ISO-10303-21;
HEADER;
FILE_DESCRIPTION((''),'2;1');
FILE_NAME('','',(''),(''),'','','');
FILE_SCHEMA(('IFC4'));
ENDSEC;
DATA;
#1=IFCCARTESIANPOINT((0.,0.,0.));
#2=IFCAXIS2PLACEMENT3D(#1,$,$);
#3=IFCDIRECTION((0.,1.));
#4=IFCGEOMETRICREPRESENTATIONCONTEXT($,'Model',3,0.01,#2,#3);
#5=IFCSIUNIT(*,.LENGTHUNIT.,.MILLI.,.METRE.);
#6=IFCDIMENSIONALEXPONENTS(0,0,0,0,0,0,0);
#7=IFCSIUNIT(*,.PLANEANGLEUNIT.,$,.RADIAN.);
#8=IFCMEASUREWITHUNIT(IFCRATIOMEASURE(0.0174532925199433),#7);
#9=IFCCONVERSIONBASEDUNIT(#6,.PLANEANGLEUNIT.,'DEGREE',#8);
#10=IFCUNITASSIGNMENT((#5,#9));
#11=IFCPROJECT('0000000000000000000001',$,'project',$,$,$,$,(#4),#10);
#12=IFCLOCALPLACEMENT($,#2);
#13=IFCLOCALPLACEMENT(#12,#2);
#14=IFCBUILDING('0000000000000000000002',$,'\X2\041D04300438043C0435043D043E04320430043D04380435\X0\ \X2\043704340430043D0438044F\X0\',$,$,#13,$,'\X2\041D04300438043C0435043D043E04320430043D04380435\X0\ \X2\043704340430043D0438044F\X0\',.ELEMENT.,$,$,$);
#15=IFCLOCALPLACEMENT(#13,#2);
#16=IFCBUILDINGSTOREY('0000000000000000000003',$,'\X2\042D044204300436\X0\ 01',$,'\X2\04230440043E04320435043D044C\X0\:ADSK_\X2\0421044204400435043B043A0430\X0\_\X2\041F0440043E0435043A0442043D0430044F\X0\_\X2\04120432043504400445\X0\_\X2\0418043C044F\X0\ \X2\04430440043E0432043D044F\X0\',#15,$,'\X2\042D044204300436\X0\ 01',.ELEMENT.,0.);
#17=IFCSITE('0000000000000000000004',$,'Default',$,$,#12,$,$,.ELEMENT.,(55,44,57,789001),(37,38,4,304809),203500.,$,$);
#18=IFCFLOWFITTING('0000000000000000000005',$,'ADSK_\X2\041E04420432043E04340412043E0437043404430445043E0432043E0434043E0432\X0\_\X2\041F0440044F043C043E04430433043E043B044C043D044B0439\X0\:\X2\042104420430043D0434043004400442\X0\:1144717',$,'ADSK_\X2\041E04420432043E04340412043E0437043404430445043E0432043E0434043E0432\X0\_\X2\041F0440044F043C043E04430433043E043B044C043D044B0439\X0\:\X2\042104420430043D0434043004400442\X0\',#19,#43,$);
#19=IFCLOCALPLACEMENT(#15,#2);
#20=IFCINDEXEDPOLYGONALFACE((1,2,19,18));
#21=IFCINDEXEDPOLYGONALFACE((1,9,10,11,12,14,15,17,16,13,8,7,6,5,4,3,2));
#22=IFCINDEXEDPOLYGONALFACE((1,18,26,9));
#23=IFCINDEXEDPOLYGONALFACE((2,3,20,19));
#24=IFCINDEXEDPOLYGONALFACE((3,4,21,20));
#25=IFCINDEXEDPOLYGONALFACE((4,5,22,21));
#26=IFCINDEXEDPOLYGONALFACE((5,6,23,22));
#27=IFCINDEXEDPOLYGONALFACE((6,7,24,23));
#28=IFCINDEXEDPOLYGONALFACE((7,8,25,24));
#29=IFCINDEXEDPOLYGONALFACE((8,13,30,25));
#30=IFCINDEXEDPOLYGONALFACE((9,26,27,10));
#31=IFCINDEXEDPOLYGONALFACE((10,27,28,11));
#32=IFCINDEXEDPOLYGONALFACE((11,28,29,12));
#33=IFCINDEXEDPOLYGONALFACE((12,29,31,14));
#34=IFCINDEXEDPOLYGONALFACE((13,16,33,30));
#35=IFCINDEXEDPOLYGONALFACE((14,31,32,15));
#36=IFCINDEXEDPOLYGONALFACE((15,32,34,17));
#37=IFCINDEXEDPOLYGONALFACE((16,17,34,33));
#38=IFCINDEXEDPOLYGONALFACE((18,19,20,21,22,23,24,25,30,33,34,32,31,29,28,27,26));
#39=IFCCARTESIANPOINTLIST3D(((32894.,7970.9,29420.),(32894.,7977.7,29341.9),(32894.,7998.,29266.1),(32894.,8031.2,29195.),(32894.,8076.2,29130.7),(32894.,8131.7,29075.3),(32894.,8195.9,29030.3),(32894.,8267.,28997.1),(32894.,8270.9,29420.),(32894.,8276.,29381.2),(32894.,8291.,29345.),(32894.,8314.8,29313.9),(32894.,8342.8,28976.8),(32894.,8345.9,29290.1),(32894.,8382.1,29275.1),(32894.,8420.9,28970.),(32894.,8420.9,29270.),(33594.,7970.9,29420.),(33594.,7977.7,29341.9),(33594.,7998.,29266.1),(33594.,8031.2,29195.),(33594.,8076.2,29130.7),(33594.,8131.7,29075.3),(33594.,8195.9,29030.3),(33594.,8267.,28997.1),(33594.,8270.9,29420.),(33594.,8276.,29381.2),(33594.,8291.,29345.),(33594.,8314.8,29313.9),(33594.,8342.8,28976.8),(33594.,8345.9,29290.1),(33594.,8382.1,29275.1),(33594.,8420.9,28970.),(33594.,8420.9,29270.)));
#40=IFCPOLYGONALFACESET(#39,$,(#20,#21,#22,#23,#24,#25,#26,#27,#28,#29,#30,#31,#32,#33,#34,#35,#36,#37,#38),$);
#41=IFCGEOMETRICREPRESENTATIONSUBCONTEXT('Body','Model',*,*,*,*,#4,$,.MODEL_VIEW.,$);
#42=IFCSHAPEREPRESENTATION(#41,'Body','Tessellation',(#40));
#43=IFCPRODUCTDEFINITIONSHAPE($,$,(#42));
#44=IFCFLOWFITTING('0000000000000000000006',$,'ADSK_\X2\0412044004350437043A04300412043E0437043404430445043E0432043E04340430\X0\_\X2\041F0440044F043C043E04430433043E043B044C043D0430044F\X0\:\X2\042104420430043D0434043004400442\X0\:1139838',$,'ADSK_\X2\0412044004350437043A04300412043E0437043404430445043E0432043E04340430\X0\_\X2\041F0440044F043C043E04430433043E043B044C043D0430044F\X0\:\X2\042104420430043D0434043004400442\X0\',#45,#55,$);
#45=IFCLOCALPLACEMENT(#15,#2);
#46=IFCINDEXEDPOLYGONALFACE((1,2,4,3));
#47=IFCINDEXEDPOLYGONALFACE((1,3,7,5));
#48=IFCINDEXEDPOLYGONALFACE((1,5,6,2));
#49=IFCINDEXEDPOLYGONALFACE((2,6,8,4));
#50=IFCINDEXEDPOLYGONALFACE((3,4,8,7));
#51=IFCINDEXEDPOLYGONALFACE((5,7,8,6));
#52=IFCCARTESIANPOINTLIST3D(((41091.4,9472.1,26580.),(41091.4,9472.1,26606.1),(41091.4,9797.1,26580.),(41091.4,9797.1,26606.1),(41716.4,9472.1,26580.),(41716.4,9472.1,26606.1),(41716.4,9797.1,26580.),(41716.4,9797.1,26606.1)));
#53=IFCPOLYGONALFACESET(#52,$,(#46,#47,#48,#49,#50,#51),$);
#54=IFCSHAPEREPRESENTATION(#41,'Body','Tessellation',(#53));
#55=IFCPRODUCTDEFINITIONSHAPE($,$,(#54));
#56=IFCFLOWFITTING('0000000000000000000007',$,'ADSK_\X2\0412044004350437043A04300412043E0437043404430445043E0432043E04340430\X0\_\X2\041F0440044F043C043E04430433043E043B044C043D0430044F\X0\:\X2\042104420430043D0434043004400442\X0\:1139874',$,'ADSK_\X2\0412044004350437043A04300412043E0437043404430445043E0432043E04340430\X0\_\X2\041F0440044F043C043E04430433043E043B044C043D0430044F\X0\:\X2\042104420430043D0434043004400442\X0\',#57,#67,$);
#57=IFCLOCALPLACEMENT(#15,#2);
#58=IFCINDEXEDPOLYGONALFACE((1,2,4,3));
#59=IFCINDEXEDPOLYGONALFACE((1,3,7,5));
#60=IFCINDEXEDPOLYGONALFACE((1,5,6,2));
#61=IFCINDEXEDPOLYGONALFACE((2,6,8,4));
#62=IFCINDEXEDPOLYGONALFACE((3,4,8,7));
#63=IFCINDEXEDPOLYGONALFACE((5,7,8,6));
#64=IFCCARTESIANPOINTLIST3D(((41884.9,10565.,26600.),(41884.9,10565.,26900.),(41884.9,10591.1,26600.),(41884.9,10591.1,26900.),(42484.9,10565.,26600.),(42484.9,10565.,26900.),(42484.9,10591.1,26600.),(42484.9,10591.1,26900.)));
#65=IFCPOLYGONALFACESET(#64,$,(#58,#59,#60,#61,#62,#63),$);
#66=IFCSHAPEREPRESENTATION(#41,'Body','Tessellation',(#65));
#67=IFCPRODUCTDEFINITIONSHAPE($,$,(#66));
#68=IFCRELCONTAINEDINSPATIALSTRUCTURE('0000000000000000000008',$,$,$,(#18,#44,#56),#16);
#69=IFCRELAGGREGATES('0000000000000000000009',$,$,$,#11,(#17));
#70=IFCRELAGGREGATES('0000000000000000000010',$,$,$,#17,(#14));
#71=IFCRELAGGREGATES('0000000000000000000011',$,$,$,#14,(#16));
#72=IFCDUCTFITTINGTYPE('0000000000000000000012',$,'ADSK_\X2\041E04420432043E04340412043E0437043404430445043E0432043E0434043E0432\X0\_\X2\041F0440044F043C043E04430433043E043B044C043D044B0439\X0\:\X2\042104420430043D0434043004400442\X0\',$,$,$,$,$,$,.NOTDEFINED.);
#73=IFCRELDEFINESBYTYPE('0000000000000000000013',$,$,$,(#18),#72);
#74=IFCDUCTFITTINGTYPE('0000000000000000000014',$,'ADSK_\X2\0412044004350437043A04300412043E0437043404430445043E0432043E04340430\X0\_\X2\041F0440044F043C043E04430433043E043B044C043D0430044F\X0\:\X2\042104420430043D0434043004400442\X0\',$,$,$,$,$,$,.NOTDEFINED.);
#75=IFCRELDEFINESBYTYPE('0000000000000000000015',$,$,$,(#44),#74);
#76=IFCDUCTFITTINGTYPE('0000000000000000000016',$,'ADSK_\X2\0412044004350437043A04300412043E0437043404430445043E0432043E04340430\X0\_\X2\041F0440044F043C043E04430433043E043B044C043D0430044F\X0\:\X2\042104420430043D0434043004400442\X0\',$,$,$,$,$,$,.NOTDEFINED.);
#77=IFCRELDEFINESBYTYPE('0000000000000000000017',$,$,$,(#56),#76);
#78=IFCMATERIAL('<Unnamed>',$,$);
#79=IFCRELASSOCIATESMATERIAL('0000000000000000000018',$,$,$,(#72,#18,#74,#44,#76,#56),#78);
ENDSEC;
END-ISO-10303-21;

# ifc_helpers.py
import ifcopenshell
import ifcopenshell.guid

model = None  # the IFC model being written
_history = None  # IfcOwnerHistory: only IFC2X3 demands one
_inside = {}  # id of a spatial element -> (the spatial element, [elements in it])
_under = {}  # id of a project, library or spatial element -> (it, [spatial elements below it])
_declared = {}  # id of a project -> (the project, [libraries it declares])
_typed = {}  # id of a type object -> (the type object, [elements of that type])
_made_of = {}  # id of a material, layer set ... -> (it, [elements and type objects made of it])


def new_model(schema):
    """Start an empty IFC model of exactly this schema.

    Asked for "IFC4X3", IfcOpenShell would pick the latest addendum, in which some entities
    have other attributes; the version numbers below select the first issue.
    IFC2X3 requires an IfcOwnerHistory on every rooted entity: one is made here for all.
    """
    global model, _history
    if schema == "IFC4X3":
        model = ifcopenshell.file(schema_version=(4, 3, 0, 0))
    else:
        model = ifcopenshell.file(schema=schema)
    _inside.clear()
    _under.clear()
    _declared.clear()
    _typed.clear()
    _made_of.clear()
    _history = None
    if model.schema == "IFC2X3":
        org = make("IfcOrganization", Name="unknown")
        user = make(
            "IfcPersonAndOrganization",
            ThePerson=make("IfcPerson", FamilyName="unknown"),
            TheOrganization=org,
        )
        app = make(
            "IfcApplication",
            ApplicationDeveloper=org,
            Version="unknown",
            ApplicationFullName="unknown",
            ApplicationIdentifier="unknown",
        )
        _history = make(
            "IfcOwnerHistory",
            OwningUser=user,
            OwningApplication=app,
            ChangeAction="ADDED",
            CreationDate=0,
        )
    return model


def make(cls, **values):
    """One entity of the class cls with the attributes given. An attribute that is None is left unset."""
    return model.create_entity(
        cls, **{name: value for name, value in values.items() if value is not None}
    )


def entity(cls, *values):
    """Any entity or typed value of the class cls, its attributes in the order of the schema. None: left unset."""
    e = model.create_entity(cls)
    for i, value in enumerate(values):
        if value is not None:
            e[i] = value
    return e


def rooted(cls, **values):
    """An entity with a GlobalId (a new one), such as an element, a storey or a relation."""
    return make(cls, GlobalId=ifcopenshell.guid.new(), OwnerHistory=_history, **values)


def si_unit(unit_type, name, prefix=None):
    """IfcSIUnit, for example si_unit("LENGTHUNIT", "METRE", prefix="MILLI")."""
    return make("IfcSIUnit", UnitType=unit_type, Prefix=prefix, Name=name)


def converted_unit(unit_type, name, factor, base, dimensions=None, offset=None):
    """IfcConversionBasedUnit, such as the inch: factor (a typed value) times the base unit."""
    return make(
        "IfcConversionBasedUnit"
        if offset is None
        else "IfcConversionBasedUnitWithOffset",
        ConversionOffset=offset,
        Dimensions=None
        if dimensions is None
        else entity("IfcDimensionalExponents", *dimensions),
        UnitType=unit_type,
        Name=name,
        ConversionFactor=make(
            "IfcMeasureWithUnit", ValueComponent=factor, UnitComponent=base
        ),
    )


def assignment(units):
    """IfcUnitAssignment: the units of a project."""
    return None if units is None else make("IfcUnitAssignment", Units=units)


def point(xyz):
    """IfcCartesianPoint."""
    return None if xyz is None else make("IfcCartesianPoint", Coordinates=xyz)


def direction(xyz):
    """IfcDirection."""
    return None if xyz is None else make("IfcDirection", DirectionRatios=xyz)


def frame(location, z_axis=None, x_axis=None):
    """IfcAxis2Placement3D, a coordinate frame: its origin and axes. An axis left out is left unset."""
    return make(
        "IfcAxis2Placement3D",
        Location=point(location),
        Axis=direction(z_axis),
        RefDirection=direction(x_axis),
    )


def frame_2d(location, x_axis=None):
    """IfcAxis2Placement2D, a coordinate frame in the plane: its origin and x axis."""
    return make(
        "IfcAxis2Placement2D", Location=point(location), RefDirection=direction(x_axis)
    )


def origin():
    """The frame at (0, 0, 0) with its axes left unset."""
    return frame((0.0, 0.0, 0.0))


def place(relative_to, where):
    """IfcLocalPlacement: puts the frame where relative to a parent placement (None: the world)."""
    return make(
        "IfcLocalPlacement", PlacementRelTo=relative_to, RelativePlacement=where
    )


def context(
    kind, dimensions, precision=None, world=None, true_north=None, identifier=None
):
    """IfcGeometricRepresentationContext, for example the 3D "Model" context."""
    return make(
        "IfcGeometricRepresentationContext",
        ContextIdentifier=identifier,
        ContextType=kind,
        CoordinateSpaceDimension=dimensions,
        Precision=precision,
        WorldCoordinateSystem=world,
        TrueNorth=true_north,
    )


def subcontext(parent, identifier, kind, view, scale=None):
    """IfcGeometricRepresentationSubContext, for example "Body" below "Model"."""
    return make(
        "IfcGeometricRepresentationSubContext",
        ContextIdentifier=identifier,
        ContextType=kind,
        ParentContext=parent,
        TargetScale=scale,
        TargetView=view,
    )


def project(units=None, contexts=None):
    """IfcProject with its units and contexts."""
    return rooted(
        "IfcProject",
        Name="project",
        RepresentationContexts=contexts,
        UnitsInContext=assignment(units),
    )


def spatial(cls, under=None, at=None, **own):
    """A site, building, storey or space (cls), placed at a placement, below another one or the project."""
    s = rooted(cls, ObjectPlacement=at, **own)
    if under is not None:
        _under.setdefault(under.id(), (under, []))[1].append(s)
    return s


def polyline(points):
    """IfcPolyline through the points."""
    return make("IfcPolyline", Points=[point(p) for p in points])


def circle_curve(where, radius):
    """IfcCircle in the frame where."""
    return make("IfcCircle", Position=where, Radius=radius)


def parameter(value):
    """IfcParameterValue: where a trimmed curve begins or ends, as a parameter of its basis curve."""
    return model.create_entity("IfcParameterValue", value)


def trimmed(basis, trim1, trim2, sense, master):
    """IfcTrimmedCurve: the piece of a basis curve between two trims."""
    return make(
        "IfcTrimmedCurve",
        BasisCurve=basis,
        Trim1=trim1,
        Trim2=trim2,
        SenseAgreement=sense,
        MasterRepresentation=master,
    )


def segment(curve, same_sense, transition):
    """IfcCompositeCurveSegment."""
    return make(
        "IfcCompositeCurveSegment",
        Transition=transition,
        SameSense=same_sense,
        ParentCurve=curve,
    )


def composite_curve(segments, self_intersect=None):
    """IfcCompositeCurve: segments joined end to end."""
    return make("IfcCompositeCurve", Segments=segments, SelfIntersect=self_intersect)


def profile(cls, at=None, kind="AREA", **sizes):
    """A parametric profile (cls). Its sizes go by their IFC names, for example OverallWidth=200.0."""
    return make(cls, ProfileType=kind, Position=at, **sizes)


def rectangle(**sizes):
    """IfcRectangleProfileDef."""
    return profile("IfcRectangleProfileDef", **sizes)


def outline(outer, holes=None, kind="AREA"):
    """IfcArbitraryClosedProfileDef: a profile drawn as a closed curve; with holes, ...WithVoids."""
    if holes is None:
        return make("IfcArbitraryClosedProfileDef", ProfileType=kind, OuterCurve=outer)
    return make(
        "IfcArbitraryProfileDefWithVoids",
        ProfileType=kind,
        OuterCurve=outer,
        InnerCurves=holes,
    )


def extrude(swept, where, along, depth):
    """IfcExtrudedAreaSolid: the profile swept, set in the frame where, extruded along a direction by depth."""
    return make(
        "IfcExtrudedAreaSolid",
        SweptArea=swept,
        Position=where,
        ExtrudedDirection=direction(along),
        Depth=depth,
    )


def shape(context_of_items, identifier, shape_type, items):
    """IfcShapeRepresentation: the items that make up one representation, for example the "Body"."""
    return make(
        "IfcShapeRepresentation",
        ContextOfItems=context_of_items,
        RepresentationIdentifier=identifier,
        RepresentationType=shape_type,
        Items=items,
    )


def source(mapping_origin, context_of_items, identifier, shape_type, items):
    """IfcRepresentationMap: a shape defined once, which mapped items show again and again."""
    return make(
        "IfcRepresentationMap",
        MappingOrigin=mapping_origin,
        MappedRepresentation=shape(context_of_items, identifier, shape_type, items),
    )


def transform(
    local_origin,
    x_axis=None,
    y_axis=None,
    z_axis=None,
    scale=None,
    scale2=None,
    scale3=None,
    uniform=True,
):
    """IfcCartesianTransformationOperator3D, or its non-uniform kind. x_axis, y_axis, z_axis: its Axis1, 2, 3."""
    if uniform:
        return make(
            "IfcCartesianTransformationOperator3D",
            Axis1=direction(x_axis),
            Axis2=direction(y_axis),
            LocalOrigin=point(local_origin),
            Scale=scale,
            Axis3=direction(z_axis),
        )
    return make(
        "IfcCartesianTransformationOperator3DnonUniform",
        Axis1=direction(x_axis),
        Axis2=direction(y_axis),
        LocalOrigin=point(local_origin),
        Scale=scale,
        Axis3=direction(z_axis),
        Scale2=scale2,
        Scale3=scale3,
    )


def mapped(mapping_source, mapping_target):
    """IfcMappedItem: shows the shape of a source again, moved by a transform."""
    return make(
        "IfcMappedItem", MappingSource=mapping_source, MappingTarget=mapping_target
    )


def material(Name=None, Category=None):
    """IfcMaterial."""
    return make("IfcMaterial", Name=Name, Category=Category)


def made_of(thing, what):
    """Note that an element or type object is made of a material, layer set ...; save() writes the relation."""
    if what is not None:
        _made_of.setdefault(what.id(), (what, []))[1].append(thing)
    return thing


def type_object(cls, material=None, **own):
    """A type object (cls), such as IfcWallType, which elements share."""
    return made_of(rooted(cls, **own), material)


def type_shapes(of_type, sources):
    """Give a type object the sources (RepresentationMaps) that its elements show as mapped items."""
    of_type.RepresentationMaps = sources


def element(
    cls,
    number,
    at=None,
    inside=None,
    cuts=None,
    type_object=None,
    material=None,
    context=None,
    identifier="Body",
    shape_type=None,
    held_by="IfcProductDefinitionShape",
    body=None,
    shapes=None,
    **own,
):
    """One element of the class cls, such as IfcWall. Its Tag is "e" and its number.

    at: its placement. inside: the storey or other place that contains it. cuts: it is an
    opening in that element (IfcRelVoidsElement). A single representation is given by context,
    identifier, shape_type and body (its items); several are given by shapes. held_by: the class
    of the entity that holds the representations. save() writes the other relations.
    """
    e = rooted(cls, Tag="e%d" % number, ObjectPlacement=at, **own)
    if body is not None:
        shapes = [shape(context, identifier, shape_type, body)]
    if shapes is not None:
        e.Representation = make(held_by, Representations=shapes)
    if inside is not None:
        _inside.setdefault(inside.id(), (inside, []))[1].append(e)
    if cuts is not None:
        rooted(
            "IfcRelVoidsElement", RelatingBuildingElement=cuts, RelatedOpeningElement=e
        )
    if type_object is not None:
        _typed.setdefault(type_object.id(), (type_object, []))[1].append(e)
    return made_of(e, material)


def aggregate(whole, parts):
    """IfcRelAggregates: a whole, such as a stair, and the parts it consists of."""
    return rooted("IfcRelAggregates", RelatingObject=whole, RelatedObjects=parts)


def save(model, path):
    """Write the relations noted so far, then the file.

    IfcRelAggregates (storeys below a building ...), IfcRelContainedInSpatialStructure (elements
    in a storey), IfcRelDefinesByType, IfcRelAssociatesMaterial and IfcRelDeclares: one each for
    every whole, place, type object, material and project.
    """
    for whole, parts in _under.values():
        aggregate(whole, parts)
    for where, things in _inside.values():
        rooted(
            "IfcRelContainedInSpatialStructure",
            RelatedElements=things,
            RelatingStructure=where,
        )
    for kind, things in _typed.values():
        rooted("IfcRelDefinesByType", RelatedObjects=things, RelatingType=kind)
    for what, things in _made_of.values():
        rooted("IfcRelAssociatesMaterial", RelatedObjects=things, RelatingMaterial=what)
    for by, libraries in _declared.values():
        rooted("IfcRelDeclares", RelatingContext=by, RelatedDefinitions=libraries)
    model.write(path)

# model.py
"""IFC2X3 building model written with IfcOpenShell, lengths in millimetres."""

from ifc_helpers import new_model, entity, si_unit, converted_unit, direction, frame, frame_2d, origin, place, context, subcontext, project, spatial, polyline, circle_curve, parameter, trimmed, segment, composite_curve, rectangle, outline, extrude, source, transform, mapped, material, type_object, type_shapes, element, save


model = new_model("IFC2X3")

# Units and contexts
model_context = context("Model", 3, precision=0.01, world=origin(), true_north=direction((0.0, 1.0)))
body_context = subcontext(model_context, "Body", "Model", "MODEL_VIEW")
ifc_project = project(units=[si_unit("LENGTHUNIT", "METRE", prefix="MILLI"), converted_unit("PLANEANGLEUNIT", "DEGREE", entity("IfcRatioMeasure", 0.0174532925199433), si_unit("PLANEANGLEUNIT", "RADIAN"), dimensions=[0, 0, 0, 0, 0, 0, 0])], contexts=[model_context])

# Site, building, storey
site_placement = place(None, frame((0.0, 0.0, 0.0)))
site = spatial("IfcSite", under=ifc_project, at=site_placement, Name="Default", CompositionType="ELEMENT", RefLatitude=(55, 44, 57, 789001), RefLongitude=(37, 38, 4, 304809), RefElevation=203500.0)
building_placement = place(site_placement, origin())
building = spatial("IfcBuilding", under=site, at=building_placement, Name="Наименование здания", LongName="Наименование здания", CompositionType="ELEMENT")
storey_placement = place(building_placement, origin())
storey = spatial("IfcBuildingStorey", under=building, at=storey_placement, Name="Этаж 01", ObjectType="Уровень:ADSK_Стрелка_Проектная_Вверх_Имя уровня", LongName="Этаж 01", CompositionType="ELEMENT", Elevation=0.0)

# Shared definitions
ifc_material_1 = material(Name="<Unnamed>")

# Flow fittings
duct_fitting_type_1 = type_object("IfcDuctFittingType", Name="ADSK_ОтводВоздуховодов_Прямоугольный:Стандарт", PredefinedType="NOTDEFINED", material=ifc_material_1)
shared_shape_1 = source(origin(), body_context, "Body", "SweptSolid", [
    extrude(outline(composite_curve([segment(polyline([(-300.0, -150.0), (0.0, -150.0)]), True, "CONTINUOUS"), segment(trimmed(circle_curve(frame_2d((150.0, -150.0), x_axis=(0.0, 1.0)), 150.0), [parameter(0.0)], [parameter(90.0)], True, "PARAMETER"), False, "CONTINUOUS"), segment(polyline([(150.0, 0.0), (150.0, 300.0)]), True, "CONTINUOUS"), segment(trimmed(circle_curve(frame_2d((150.0, -150.0), x_axis=(0.0, 1.0)), 450.0), [parameter(0.0)], [parameter(90.0)], True, "PARAMETER"), True, "CONTINUOUS")], self_intersect=False)), frame((-150.0, 150.0, -350.0), z_axis=(0.0, 0.0, 1.0), x_axis=(-1.0, 0.0, 0.0)), (0.0, 0.0, 1.0), 700.0),
])
type_shapes(duct_fitting_type_1, [shared_shape_1])
for number, where, z_axis, x_axis, name in (
    (1, (33244.0, 8120.9, 29120.0), (1.0, 0.0, 0.0), (0.0, 0.0, -1.0), "ADSK_ОтводВоздуховодов_Прямоугольный:Стандарт:1144717"),
):
    element("IfcFlowFitting", number, at=place(storey_placement, frame(where, z_axis=z_axis, x_axis=x_axis)), inside=storey, type_object=duct_fitting_type_1, material=ifc_material_1, Name=name, ObjectType="ADSK_ОтводВоздуховодов_Прямоугольный:Стандарт", context=body_context, shape_type="MappedRepresentation", body=[
        mapped(shared_shape_1, transform((0.0, 0.0, 0.0), scale=1.0)),
    ])
duct_fitting_type_2 = type_object("IfcDuctFittingType", Name="ADSK_ВрезкаВоздуховода_Прямоугольная:Стандарт", PredefinedType="NOTDEFINED", material=ifc_material_1)
shared_shape_2 = source(origin(), body_context, "Body", "SweptSolid", [
    extrude(rectangle(XDim=625.0, YDim=26.1, at=frame_2d((0.0, 0.0), x_axis=(1.0, 0.0))), frame((7.0, 0.0, -162.5), z_axis=(0.0, 0.0, 1.0), x_axis=(0.0, -1.0, 0.0)), (0.0, 0.0, 1.0), 325.0),
])
type_shapes(duct_fitting_type_2, [shared_shape_2])
flow_fitting_1_placement = place(storey_placement, frame((41403.9, 9634.6, 26600.0), z_axis=(0.0, 1.0, 0.0), x_axis=(0.0, 0.0, -1.0)))
element("IfcFlowFitting", 2, at=flow_fitting_1_placement, inside=storey, type_object=duct_fitting_type_2, material=ifc_material_1, Name="ADSK_ВрезкаВоздуховода_Прямоугольная:Стандарт:1139838", ObjectType="ADSK_ВрезкаВоздуховода_Прямоугольная:Стандарт", context=body_context, shape_type="MappedRepresentation", body=[
    mapped(shared_shape_2, transform((0.0, 0.0, 0.0), scale=1.0)),
])
duct_fitting_type_3 = type_object("IfcDuctFittingType", Name="ADSK_ВрезкаВоздуховода_Прямоугольная:Стандарт", PredefinedType="NOTDEFINED", material=ifc_material_1)
shared_shape_3 = source(origin(), body_context, "Body", "SweptSolid", [
    extrude(rectangle(XDim=26.1, YDim=300.0, at=frame_2d((0.0, 0.0), x_axis=(1.0, 0.0))), frame((7.0, 0.0, -300.0)), (0.0, 0.0, 1.0), 600.0),
])
type_shapes(duct_fitting_type_3, [shared_shape_3])
flow_fitting_2_placement = place(storey_placement, frame((42184.9, 10585.0, 26750.0), z_axis=(-1.0, 0.0, 0.0), x_axis=(0.0, -1.0, 0.0)))
element("IfcFlowFitting", 3, at=flow_fitting_2_placement, inside=storey, type_object=duct_fitting_type_3, material=ifc_material_1, Name="ADSK_ВрезкаВоздуховода_Прямоугольная:Стандарт:1139874", ObjectType="ADSK_ВрезкаВоздуховода_Прямоугольная:Стандарт", context=body_context, shape_type="MappedRepresentation", body=[
    mapped(shared_shape_3, transform((0.0, 0.0, 0.0), scale=1.0)),
])

save(model, "model.ifc")
